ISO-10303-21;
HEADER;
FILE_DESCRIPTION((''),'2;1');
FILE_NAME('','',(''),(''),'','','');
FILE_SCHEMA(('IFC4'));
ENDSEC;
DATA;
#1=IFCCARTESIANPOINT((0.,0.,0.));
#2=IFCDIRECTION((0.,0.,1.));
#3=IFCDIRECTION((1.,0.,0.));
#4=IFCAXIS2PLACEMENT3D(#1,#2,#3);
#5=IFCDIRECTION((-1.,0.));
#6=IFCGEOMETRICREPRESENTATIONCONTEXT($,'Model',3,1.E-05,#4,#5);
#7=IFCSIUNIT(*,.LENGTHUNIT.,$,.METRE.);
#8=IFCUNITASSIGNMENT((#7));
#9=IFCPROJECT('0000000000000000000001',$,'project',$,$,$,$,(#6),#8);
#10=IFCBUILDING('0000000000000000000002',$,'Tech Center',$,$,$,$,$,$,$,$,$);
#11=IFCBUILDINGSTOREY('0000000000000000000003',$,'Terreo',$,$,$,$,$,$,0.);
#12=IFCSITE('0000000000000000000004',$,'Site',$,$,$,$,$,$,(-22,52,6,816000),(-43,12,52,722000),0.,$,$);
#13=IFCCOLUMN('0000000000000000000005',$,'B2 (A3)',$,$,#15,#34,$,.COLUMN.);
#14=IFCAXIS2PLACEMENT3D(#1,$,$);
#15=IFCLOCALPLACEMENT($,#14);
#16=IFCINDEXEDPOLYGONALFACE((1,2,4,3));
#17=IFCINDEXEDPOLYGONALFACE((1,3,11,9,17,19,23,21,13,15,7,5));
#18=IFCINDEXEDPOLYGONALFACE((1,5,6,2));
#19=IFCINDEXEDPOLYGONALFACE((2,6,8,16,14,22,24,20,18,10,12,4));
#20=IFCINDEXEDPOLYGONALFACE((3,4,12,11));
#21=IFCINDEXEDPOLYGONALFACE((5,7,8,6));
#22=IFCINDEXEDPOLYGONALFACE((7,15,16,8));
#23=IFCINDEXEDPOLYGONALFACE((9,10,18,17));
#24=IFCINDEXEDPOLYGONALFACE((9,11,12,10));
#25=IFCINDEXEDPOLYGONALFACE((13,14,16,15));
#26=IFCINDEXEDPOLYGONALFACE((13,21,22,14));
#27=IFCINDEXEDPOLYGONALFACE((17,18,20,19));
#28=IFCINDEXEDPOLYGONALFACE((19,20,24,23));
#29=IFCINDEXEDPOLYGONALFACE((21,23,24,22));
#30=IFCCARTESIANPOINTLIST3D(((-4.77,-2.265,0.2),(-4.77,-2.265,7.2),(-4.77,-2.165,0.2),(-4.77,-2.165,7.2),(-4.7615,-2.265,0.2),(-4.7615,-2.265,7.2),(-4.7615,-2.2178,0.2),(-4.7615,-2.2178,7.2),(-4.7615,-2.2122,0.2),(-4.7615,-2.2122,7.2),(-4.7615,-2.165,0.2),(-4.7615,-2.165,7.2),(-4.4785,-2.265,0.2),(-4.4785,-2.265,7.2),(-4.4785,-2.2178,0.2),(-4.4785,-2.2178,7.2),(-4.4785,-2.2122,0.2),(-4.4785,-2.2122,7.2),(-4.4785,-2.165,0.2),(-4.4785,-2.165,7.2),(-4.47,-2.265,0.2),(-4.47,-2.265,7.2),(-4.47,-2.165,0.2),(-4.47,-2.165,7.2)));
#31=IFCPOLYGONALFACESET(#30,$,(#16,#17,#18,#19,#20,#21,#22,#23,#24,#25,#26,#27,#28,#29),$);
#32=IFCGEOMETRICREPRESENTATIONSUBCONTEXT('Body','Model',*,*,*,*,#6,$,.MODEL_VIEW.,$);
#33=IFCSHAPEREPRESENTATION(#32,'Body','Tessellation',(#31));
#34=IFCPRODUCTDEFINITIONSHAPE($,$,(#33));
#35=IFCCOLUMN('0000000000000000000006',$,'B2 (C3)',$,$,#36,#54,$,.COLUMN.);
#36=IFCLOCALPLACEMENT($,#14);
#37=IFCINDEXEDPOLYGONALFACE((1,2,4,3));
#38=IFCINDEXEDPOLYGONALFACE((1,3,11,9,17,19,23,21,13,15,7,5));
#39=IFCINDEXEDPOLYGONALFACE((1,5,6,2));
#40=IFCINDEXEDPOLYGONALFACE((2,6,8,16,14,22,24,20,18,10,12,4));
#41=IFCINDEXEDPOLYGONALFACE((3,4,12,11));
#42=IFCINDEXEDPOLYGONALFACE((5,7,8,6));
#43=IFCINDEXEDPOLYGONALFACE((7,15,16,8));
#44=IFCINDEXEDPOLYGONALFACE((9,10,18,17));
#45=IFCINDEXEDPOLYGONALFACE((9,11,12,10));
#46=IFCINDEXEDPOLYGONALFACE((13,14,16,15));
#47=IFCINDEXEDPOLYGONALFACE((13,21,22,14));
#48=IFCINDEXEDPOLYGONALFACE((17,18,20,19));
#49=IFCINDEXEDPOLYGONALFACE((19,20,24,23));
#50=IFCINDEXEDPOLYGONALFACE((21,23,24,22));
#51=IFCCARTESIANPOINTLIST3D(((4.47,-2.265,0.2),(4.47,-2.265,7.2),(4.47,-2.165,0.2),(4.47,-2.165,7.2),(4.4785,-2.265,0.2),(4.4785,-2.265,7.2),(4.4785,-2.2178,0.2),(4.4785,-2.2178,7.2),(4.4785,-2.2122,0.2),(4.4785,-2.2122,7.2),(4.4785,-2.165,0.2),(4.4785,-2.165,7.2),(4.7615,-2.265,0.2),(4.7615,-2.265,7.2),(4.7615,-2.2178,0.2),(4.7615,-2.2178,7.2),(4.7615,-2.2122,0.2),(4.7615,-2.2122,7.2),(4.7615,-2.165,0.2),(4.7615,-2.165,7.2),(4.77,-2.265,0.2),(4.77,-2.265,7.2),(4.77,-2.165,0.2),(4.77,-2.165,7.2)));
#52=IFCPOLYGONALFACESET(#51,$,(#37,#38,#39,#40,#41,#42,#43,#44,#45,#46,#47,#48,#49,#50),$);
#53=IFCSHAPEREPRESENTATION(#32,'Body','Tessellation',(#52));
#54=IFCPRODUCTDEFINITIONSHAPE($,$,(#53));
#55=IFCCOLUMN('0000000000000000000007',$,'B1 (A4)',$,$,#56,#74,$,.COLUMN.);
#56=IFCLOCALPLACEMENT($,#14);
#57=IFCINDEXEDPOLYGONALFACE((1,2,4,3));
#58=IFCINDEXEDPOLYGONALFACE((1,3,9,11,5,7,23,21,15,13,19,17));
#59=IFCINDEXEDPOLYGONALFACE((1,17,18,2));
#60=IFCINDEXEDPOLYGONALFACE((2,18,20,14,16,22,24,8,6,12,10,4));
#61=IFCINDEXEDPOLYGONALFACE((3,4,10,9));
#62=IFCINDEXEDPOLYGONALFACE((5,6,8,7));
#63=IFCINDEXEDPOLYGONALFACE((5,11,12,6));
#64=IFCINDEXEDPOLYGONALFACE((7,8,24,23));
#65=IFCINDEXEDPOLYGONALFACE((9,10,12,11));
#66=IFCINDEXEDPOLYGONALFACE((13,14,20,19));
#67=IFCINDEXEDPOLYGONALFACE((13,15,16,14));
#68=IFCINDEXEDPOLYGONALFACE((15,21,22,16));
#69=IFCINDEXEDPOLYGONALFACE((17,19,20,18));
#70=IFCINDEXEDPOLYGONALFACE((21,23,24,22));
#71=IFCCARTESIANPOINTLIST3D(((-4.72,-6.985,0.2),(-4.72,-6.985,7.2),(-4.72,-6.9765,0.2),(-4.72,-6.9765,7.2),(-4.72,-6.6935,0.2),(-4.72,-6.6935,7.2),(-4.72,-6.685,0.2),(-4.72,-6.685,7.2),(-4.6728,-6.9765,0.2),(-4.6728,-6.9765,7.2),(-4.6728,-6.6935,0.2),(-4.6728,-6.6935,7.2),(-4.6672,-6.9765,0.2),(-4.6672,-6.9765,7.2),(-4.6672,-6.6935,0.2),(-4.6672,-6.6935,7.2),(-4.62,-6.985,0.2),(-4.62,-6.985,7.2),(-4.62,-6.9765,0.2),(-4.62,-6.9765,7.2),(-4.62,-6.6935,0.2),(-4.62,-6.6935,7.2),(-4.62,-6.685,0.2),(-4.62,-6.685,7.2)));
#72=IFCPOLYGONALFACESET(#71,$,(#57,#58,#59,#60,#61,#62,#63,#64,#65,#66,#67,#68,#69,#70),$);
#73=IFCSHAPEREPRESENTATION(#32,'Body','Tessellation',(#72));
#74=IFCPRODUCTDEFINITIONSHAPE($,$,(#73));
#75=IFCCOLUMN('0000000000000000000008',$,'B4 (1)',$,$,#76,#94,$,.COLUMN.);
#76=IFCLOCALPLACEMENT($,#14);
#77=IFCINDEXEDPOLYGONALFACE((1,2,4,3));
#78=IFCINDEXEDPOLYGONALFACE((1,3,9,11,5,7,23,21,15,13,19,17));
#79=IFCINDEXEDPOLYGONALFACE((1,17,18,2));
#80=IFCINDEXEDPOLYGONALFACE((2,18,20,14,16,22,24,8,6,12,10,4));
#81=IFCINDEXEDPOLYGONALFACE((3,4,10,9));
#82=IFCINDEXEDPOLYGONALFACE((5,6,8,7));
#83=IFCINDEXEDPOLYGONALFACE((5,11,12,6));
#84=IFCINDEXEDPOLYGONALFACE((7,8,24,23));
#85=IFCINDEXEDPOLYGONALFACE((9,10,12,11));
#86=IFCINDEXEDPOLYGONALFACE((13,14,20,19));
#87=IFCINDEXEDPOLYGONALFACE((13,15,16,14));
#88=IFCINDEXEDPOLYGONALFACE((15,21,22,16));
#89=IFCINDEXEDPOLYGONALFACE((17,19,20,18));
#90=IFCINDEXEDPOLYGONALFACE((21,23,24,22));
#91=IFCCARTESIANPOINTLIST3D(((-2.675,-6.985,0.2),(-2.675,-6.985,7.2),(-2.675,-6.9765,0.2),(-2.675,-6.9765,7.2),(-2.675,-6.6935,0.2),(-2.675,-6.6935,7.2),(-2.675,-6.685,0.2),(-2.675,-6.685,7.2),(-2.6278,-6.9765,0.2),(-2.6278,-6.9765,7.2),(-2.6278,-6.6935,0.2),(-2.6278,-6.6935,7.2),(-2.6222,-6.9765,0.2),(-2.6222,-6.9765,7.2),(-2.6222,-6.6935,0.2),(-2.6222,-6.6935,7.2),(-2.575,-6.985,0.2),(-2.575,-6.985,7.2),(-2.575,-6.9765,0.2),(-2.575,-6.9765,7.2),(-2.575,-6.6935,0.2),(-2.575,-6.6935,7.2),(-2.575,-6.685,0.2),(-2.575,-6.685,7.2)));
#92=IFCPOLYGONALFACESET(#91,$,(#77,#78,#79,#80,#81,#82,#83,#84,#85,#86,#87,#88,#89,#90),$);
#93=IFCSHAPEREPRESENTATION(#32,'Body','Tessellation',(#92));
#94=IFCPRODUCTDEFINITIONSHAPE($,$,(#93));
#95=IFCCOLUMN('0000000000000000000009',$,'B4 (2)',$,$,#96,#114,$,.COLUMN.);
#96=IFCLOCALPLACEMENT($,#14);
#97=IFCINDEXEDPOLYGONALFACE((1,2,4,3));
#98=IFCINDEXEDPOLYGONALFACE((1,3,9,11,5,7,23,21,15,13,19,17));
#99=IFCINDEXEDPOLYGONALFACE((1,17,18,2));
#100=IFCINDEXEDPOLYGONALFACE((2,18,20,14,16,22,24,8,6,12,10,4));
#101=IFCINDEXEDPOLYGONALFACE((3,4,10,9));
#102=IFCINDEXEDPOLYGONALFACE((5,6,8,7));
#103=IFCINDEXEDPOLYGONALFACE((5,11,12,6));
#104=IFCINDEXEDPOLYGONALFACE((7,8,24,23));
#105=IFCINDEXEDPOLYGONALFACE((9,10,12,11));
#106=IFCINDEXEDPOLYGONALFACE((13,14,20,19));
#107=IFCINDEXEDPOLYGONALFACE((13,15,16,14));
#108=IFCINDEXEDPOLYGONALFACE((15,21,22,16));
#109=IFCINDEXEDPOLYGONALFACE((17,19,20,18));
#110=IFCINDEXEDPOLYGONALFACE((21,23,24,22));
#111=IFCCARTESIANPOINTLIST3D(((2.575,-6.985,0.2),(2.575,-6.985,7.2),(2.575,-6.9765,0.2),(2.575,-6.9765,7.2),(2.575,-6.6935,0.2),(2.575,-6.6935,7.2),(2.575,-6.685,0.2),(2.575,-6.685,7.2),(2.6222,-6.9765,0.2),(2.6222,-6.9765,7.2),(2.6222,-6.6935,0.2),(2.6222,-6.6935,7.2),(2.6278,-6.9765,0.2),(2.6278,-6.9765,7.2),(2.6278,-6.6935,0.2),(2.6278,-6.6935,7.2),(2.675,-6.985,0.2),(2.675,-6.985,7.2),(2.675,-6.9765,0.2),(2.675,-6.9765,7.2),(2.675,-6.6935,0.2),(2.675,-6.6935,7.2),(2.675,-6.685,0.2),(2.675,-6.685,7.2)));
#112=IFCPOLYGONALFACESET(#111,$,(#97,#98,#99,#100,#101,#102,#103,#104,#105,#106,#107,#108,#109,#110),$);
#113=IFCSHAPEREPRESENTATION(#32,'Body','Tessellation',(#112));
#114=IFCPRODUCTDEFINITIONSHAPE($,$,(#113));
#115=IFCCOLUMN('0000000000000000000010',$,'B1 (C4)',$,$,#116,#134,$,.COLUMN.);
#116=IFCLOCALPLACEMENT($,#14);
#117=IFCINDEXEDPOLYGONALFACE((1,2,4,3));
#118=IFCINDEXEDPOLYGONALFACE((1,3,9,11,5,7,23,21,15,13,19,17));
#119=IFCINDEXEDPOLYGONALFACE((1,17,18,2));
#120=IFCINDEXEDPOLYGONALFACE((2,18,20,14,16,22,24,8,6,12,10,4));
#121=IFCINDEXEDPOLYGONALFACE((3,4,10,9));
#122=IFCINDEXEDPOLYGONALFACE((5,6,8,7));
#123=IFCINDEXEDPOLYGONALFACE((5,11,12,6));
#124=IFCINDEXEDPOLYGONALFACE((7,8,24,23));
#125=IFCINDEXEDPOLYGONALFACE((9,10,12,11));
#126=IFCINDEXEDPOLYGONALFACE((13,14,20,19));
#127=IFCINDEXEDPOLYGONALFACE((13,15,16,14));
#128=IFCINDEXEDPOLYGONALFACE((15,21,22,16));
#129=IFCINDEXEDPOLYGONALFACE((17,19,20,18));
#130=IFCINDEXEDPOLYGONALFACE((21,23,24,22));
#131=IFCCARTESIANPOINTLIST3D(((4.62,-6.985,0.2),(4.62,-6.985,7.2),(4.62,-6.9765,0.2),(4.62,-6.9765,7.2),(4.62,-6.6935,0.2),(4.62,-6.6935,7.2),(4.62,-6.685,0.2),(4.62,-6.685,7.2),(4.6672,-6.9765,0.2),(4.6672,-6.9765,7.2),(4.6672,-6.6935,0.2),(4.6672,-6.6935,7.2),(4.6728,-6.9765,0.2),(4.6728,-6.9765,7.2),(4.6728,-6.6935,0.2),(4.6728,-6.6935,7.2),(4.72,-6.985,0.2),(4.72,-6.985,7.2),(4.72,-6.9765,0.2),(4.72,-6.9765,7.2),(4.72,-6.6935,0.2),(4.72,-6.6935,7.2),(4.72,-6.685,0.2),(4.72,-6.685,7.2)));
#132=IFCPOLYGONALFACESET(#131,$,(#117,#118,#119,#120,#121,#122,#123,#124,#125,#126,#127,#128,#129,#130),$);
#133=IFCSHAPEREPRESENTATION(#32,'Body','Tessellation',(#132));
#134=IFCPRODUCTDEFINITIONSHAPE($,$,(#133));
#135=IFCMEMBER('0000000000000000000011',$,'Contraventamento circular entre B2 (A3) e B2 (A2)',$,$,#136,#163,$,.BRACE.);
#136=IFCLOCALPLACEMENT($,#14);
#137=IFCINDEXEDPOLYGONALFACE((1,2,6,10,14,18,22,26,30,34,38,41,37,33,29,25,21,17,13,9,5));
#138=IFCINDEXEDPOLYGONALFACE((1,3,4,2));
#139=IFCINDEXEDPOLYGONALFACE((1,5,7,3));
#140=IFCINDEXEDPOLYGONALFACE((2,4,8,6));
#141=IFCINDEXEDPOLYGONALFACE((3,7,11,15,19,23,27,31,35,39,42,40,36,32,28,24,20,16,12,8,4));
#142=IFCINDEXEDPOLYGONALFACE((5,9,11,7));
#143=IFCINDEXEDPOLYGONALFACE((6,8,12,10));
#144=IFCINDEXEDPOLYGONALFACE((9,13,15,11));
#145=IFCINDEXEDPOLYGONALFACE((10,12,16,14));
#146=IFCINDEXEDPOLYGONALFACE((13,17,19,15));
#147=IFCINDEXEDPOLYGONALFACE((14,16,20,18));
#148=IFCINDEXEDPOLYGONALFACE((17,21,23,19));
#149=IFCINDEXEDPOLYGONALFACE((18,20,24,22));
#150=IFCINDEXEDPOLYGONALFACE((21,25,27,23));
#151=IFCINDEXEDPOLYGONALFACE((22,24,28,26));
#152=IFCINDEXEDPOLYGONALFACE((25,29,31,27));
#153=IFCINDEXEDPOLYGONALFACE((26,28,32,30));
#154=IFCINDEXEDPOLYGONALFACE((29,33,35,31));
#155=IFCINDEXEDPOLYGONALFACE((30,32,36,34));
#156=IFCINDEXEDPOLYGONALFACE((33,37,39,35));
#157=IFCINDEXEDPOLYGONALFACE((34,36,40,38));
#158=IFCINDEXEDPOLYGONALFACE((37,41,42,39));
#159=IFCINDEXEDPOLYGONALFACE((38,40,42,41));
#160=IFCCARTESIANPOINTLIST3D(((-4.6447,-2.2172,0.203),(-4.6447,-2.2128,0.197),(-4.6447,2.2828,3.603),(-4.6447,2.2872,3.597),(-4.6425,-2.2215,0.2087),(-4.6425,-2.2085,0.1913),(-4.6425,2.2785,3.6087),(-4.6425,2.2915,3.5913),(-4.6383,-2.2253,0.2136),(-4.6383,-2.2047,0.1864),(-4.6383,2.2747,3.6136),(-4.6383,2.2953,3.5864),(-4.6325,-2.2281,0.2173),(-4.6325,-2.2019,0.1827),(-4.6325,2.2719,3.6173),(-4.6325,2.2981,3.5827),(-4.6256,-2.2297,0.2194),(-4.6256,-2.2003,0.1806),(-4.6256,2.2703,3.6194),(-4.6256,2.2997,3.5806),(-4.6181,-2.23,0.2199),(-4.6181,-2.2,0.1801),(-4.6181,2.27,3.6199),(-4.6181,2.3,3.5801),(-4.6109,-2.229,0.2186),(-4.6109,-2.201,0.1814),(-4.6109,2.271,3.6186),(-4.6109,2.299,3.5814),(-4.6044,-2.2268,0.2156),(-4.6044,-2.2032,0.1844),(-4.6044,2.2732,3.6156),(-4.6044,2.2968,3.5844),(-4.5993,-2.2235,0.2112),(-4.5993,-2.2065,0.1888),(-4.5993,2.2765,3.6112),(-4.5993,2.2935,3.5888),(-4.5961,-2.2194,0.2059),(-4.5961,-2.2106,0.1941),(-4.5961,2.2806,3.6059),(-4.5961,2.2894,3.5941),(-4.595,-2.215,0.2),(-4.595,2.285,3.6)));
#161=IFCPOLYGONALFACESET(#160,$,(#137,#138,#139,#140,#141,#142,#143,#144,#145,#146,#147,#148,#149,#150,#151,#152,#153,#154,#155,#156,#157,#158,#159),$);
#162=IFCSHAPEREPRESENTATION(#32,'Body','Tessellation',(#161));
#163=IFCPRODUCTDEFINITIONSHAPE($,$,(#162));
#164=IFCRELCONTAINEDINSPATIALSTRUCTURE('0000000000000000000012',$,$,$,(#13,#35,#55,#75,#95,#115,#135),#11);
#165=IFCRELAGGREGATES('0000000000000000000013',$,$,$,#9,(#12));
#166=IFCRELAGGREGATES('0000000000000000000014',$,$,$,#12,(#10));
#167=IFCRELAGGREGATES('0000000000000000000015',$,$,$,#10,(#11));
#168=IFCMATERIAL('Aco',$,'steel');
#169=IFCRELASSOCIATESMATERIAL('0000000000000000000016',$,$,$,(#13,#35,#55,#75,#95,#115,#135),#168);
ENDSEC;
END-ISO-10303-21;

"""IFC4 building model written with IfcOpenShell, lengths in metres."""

from ifc_helpers import new_model, si_unit, direction, frame, origin_with_axes, place, context, subcontext, project, spatial, circle, i_section, extrude, material, element, save


model = new_model("IFC4")

# Units and contexts
model_context = context("Model", 3, precision=1e-05, world=origin_with_axes(), true_north=direction((-1.0, 0.0)))
body_context = subcontext(model_context, "Body", "Model", "MODEL_VIEW")
ifc_project = project(units=[si_unit("LENGTHUNIT", "METRE")], contexts=[model_context])

# Site, building, storey
site = spatial("IfcSite", under=ifc_project, Name="Site", RefLatitude=(-22, 52, 6, 816000), RefLongitude=(-43, 12, 52, 722000), RefElevation=0.0)
building = spatial("IfcBuilding", under=site, Name="Tech Center")
storey = spatial("IfcBuildingStorey", under=building, Name="Terreo", Elevation=0.0)

# Columns
ifc_material_1 = material(Name="Aco", Category="steel")
for number, where, z_axis, x_axis, name in (
    (1, (-4.62, -2.215, 0.2), (0.0, 0.0, 1.0), (0.0, 1.0, 0.0), "B2 (A3)"),
    (2, (4.62, -2.215, 0.2), (0.0, 0.0, 1.0), (0.0, 1.0, 0.0), "B2 (C3)"),
    (3, (-4.67, -6.835, 0.2), (0.0, 0.0, 1.0), (1.0, 0.0, 0.0), "B1 (A4)"),
    (4, (-2.625, -6.835, 0.2), (0.0, 0.0, 1.0), (1.0, 0.0, 0.0), "B4 (1)"),
    (5, (2.625, -6.835, 0.2), (0.0, 0.0, 1.0), (1.0, 0.0, 0.0), "B4 (2)"),
    (6, (4.67, -6.835, 0.2), (0.0, 0.0, 1.0), (1.0, 0.0, 0.0), "B1 (C4)"),
):
    element("IfcColumn", number, at=place(None, frame(where, z_axis=z_axis, x_axis=x_axis)), inside=storey, material=ifc_material_1, Name=name, PredefinedType="COLUMN", context=body_context, shape_type="SweptSolid", body=[
        extrude(i_section(OverallWidth=0.1, OverallDepth=0.3, WebThickness=0.0056, FlangeThickness=0.0085), origin_with_axes(), (0.0, 0.0, 1.0), 7.0),
    ])

# Member
member_placement = place(None, frame((-4.62, -2.215, 0.2), z_axis=(0.0, 0.797867, 0.602833), x_axis=(1.0, 0.0, 0.0)))
element("IfcMember", 7, at=member_placement, inside=storey, material=ifc_material_1, Name="Contraventamento circular entre B2 (A3) e B2 (A2)", PredefinedType="BRACE", context=body_context, shape_type="SweptSolid", body=[
    extrude(circle(Radius=0.025), origin_with_axes(), (0.0, 0.0, 1.0), 5.64),
])

save(model, "model.ifc")
